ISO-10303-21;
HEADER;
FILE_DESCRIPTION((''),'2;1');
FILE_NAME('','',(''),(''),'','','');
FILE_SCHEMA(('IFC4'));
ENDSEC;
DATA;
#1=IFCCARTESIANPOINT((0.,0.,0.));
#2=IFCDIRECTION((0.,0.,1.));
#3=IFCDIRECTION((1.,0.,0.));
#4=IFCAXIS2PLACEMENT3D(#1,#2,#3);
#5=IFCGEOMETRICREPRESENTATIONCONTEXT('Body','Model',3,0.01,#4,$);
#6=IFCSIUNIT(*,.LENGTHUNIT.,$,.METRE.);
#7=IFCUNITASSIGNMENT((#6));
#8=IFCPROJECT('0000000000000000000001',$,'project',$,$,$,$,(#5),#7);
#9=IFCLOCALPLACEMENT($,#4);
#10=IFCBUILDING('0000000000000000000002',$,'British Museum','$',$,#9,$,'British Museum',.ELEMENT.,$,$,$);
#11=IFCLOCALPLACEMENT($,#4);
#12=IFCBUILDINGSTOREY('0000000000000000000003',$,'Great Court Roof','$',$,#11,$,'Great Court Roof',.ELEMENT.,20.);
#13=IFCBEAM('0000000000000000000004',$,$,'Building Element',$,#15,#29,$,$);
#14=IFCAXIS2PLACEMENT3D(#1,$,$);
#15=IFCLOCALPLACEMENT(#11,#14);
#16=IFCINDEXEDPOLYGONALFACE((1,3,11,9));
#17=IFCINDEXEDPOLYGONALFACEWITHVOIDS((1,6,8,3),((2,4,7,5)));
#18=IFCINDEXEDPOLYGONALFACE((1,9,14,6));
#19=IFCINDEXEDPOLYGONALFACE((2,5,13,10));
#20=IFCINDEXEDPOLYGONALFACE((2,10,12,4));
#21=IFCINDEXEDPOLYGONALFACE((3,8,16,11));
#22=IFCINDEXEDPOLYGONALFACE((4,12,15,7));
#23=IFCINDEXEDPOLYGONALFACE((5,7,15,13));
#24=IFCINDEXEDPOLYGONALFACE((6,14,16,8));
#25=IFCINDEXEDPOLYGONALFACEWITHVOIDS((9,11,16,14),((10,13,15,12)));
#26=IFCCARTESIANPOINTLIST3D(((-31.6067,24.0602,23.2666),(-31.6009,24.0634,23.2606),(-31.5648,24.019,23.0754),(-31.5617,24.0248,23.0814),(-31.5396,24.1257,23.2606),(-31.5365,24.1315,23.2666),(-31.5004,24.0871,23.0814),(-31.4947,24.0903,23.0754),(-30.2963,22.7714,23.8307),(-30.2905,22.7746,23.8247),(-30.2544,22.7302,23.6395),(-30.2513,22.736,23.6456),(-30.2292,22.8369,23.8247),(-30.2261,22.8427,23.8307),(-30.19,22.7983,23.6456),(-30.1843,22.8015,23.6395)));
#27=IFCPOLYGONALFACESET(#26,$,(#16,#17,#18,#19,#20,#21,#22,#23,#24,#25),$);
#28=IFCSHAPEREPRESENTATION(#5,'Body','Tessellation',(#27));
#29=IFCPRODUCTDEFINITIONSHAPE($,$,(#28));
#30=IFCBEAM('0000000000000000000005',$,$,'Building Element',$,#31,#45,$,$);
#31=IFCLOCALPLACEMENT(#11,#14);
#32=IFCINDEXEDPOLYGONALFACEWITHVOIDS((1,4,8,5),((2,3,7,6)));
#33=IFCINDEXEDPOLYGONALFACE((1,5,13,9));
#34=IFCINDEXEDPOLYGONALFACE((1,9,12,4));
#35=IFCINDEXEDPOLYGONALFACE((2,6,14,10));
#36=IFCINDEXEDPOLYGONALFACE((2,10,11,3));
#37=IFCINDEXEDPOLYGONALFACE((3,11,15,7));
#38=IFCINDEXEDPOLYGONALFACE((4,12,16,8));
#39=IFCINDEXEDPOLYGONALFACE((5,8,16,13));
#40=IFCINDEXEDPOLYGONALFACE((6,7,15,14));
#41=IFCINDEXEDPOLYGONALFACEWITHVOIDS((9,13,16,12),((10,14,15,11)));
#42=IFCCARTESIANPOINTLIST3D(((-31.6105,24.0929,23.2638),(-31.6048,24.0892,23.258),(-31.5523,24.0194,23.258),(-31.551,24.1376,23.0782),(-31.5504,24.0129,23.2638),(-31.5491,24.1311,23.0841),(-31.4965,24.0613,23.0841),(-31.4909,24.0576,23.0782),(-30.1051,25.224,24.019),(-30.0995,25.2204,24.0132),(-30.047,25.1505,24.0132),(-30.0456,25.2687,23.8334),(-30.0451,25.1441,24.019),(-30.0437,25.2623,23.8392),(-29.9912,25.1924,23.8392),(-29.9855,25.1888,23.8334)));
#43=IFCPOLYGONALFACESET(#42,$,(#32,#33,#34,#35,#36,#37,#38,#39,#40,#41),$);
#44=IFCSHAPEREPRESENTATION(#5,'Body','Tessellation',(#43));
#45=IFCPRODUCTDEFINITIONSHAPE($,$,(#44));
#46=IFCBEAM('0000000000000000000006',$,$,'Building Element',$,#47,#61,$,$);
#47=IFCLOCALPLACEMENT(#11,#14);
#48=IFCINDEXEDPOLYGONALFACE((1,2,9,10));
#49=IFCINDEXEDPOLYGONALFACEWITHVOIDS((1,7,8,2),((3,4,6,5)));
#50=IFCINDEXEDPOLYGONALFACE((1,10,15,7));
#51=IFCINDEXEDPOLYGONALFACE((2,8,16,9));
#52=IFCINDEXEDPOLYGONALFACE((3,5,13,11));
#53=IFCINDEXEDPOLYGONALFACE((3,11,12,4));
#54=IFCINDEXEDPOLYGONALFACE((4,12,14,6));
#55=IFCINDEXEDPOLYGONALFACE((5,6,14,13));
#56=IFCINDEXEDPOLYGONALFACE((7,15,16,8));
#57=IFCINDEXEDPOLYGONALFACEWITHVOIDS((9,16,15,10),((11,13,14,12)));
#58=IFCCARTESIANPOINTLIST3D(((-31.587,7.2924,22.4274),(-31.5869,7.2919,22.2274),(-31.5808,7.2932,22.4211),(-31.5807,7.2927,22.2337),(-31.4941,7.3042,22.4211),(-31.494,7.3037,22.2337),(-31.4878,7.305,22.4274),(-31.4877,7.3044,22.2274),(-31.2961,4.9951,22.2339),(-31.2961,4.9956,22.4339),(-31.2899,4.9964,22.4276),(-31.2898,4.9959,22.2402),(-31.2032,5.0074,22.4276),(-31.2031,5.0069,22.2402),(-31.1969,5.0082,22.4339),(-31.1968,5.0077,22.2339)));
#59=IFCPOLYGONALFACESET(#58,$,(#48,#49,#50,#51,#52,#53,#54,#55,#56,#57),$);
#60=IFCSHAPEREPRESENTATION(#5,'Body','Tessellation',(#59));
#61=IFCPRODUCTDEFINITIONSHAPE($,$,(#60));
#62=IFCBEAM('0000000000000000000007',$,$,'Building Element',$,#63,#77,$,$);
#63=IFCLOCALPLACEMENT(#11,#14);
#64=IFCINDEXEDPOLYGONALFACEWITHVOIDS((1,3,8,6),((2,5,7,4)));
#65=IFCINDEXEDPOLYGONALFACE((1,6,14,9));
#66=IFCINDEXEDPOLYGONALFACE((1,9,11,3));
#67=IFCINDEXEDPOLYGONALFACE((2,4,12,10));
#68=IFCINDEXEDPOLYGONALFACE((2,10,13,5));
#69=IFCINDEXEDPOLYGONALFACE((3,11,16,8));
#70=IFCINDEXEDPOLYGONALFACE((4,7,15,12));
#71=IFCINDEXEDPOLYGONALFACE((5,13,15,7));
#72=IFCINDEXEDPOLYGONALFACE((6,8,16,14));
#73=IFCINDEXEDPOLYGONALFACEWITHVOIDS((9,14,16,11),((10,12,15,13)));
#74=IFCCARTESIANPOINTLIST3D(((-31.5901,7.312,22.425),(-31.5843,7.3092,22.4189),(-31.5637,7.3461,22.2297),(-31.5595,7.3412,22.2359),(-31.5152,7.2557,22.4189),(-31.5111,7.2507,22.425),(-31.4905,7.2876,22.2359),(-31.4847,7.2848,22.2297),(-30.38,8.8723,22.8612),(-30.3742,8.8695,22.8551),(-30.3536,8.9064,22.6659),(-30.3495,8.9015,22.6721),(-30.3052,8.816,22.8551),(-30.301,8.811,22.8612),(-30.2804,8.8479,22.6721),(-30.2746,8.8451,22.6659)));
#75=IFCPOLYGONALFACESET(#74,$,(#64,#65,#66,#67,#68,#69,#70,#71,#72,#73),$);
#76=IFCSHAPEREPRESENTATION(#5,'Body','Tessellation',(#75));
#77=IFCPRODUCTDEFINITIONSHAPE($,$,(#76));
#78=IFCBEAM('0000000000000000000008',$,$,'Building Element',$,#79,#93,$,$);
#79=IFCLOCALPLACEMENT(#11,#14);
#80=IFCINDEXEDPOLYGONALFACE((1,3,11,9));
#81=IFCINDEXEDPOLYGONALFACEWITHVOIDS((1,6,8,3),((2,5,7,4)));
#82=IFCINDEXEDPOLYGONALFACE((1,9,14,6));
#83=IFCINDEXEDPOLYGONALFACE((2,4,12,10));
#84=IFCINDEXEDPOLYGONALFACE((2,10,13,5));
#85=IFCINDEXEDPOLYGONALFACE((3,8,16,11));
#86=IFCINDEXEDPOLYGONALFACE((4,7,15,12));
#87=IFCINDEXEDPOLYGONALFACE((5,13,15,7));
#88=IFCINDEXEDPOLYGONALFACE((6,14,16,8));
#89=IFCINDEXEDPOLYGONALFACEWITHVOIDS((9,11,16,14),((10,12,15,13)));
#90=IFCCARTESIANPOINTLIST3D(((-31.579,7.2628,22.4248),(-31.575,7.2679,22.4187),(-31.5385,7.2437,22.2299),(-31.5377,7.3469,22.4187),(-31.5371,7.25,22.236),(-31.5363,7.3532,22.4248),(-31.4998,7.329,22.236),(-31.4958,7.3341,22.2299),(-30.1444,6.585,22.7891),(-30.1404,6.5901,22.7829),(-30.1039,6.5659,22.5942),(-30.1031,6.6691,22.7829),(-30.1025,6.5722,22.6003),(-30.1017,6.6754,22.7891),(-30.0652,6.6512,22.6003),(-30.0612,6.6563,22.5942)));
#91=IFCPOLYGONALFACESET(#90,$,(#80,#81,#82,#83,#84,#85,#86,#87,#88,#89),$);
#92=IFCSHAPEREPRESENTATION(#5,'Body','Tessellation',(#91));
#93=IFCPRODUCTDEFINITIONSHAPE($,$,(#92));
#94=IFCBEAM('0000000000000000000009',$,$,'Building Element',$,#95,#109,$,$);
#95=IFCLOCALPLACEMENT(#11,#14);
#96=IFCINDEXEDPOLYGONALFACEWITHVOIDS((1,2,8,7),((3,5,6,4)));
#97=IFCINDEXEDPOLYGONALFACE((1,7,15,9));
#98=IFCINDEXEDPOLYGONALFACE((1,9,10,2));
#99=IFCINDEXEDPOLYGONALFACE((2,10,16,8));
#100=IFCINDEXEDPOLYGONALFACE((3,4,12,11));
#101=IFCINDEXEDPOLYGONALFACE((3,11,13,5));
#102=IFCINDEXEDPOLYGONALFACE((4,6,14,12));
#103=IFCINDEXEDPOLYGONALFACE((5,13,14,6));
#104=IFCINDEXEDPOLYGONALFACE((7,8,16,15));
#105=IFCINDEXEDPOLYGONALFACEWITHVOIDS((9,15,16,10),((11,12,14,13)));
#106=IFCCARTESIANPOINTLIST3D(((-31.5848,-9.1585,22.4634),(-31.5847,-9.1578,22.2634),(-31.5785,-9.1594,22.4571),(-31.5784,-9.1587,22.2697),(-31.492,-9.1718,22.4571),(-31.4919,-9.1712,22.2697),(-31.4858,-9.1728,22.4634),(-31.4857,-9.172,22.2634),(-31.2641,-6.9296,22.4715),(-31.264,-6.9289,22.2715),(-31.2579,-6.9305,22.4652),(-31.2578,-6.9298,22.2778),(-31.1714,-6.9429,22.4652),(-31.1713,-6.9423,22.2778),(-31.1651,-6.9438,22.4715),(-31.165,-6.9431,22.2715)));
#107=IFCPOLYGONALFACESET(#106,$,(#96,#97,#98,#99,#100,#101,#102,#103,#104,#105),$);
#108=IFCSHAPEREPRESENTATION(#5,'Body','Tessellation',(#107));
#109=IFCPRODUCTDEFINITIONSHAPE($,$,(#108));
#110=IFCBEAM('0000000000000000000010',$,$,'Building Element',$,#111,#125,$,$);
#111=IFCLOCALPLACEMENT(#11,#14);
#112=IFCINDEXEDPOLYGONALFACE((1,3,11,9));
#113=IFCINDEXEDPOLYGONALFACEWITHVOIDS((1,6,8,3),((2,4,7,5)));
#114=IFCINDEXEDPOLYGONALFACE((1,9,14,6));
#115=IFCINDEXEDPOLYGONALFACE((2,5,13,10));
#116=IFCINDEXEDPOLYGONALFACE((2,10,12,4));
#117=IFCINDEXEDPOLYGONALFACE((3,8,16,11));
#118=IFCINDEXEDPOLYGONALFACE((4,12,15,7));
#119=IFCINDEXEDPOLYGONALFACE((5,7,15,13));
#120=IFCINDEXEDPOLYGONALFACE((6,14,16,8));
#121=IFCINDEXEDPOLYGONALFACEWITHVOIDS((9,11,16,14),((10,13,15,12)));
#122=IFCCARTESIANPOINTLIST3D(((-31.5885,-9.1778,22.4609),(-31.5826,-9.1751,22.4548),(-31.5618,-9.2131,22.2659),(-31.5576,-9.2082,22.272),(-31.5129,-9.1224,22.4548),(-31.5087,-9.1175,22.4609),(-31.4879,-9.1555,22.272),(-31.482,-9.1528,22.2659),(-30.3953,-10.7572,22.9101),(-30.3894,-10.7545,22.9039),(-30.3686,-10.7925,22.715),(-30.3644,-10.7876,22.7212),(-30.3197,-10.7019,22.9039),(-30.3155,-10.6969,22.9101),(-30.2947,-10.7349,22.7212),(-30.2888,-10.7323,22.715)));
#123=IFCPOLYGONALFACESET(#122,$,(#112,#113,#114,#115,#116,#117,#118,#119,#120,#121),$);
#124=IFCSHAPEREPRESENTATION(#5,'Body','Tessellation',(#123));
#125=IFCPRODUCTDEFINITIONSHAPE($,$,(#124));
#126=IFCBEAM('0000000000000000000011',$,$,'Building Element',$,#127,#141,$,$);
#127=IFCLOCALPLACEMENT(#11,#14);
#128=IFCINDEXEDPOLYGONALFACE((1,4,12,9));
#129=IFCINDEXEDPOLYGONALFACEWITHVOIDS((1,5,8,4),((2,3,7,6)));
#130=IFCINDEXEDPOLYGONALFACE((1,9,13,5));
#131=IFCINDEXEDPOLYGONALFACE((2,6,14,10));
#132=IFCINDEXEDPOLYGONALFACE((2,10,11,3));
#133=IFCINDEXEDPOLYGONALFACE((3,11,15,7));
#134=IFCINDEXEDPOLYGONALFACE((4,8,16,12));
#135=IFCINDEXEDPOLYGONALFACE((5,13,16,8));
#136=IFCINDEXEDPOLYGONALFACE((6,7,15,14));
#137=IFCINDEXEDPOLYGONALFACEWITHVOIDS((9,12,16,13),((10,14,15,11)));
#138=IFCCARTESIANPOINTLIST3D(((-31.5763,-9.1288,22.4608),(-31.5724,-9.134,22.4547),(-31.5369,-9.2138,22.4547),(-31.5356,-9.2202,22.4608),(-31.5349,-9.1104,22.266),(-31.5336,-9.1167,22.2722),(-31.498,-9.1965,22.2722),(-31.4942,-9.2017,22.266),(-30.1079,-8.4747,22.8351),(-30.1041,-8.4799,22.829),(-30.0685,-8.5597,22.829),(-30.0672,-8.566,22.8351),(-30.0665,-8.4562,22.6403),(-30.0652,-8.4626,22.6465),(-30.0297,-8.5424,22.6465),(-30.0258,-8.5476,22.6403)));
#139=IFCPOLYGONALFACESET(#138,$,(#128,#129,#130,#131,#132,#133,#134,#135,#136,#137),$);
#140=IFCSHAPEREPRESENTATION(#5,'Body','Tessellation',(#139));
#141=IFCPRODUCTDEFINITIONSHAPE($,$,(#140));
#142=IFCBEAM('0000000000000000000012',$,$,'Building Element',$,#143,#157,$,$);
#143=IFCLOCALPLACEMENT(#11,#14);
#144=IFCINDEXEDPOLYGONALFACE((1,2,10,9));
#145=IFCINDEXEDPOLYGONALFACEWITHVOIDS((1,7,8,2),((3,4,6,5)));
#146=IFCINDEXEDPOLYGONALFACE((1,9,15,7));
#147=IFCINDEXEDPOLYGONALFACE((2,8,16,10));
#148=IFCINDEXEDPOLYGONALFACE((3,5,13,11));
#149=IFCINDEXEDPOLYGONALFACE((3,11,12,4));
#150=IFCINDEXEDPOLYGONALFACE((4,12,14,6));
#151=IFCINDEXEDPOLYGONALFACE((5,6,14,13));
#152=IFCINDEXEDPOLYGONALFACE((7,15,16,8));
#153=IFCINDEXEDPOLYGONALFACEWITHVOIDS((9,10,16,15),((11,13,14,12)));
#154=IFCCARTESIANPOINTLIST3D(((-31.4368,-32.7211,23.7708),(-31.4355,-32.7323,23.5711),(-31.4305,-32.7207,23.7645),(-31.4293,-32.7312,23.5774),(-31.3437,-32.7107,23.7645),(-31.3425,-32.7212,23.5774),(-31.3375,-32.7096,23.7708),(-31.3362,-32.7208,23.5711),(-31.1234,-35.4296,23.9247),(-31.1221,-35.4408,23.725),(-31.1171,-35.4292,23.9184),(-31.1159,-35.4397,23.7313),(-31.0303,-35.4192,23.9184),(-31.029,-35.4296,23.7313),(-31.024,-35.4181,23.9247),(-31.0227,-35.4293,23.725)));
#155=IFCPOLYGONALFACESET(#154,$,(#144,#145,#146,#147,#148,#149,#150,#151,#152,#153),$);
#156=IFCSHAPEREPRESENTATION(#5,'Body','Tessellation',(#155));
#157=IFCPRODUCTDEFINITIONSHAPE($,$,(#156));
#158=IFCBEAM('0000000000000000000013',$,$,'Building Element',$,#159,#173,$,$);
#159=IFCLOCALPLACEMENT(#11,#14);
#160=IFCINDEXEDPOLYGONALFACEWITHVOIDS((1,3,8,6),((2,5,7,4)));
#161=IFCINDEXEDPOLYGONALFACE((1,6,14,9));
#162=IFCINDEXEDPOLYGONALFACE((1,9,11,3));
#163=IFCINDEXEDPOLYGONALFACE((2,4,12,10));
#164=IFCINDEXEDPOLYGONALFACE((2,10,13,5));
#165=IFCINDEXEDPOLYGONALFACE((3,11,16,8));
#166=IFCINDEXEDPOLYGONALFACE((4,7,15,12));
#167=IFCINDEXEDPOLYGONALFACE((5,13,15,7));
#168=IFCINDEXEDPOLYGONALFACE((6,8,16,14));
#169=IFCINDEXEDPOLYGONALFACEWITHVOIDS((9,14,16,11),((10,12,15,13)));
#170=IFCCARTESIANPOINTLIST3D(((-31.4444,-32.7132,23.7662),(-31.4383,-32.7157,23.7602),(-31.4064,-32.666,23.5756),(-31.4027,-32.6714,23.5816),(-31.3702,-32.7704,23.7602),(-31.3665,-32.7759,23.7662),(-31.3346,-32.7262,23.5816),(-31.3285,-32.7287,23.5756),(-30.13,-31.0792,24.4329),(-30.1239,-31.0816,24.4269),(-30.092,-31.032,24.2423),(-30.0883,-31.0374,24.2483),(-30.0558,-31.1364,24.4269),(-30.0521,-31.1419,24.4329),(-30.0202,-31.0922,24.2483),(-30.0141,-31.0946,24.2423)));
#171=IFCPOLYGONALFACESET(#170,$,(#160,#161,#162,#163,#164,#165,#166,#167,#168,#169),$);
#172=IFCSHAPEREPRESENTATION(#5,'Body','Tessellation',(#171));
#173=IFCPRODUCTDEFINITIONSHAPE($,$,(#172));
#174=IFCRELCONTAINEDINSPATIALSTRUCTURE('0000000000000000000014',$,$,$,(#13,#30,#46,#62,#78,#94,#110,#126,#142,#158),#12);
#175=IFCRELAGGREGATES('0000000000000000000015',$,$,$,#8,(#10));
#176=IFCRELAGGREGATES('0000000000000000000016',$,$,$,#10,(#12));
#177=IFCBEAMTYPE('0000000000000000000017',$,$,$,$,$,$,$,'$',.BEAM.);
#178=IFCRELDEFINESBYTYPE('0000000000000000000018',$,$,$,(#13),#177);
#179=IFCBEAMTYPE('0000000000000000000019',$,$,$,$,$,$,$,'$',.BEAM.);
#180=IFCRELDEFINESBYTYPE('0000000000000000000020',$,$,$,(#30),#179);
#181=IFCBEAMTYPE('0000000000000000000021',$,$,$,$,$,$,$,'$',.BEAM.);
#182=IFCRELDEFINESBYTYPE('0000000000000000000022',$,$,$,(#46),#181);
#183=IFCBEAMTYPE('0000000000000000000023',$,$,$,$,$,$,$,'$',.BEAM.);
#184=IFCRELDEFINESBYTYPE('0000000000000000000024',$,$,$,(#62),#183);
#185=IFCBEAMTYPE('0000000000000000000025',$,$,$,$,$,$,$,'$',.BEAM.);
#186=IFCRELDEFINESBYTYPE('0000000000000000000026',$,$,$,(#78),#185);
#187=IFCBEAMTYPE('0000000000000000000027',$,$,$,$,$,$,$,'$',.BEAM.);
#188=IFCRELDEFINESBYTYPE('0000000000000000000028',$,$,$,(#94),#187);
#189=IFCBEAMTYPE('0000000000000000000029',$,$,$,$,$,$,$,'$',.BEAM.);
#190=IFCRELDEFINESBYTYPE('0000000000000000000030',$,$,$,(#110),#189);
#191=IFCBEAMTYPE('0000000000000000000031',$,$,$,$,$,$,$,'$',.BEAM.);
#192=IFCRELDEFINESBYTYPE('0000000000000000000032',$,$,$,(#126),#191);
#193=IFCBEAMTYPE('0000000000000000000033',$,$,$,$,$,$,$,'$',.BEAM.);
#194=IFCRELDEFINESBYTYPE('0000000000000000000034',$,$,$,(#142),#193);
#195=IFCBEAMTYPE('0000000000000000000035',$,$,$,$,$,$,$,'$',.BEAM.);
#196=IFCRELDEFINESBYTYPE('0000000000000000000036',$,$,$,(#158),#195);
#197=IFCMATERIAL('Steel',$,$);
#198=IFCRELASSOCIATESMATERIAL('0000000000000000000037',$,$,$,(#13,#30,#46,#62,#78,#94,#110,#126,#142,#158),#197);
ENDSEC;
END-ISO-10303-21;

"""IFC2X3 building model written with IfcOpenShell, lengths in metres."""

from ifc_helpers import new_model, si_unit, frame, origin_with_axes, origin_2d, place, context, project, spatial, hollow_rectangle, extrude, material, type_object, element, save


model = new_model("IFC2X3")

# Units and contexts
model_context = context("Model", 3, precision=0.01, world=origin_with_axes(), identifier="Body")
ifc_project = project(units=[si_unit("LENGTHUNIT", "METRE")], contexts=[model_context])

# Building, storey
building_placement = place(None, origin_with_axes())
building = spatial("IfcBuilding", under=ifc_project, at=building_placement, Name="British Museum", Description="$", LongName="British Museum", CompositionType="ELEMENT")
storey_placement = place(None, origin_with_axes())
storey = spatial("IfcBuildingStorey", under=building, at=storey_placement, Name="Great Court Roof", Description="$", LongName="Great Court Roof", CompositionType="ELEMENT", Elevation=20.0)

# Beams
ifc_material = material(Name="Steel")
beam_type_1 = type_object("IfcBeamType", ElementType="$", PredefinedType="BEAM")
beam_1_placement = place(None, origin_with_axes())
element("IfcBeam", 1, at=beam_1_placement, inside=storey, type_object=beam_type_1, material=ifc_material, Description="Building Element", context=model_context, shape_type="SweptSolid", body=[
    extrude(hollow_rectangle(XDim=0.1, YDim=0.2, WallThickness=0.0063, InnerFilletRadius=-0.0063, OuterFilletRadius=0.0, at=origin_2d()), frame((-31.5507, 24.0753, 23.171), z_axis=(0.681582, -0.67034, 0.293411), x_axis=(0.701202, 0.712962, 0.0)), (0.0, 0.0, 1.0), 1.9226),
])
beam_type_2 = type_object("IfcBeamType", ElementType="$", PredefinedType="BEAM")
beam_2_placement = place(None, origin_with_axes())
element("IfcBeam", 2, at=beam_2_placement, inside=storey, type_object=beam_type_2, material=ifc_material, Description="Building Element", context=model_context, shape_type="SweptSolid", body=[
    extrude(hollow_rectangle(XDim=0.1, YDim=0.2, WallThickness=0.0063, InnerFilletRadius=-0.0063, OuterFilletRadius=0.0, at=origin_2d()), frame((-31.5507, 24.0753, 23.171), z_axis=(0.742004, 0.557559, 0.372235), x_axis=(-0.600728, 0.799453, 0.0)), (0.0, 0.0, 1.0), 2.0288),
])
beam_type_3 = type_object("IfcBeamType", ElementType="$", PredefinedType="BEAM")
beam_3_placement = place(None, origin_with_axes())
element("IfcBeam", 3, at=beam_3_placement, inside=storey, type_object=beam_type_3, material=ifc_material, Description="Building Element", context=model_context, shape_type="SweptSolid", body=[
    extrude(hollow_rectangle(XDim=0.1, YDim=0.2, WallThickness=0.0063, InnerFilletRadius=-0.0063, OuterFilletRadius=0.0, at=origin_2d()), frame((-31.5374, 7.2984, 22.3274), z_axis=(0.125649, -0.992071, 0.002808), x_axis=(0.992075, 0.12565, 0.0)), (0.0, 0.0, 1.0), 2.3151),
])
beam_type_4 = type_object("IfcBeamType", ElementType="$", PredefinedType="BEAM")
beam_4_placement = place(None, origin_with_axes())
element("IfcBeam", 4, at=beam_4_placement, inside=storey, type_object=beam_type_4, material=ifc_material, Description="Building Element", context=model_context, shape_type="SweptSolid", body=[
    extrude(hollow_rectangle(XDim=0.1, YDim=0.2, WallThickness=0.0063, InnerFilletRadius=-0.0063, OuterFilletRadius=0.0, at=origin_2d()), frame((-31.5374, 7.2984, 22.3274), z_axis=(0.59841, 0.771605, 0.21571), x_axis=(-0.790209, 0.612838, 0.0)), (0.0, 0.0, 1.0), 2.0221),
])
beam_type_5 = type_object("IfcBeamType", ElementType="$", PredefinedType="BEAM")
beam_5_placement = place(None, origin_with_axes())
element("IfcBeam", 5, at=beam_5_placement, inside=storey, type_object=beam_type_5, material=ifc_material, Description="Building Element", context=model_context, shape_type="SweptSolid", body=[
    extrude(hollow_rectangle(XDim=0.1, YDim=0.2, WallThickness=0.0063, InnerFilletRadius=-0.0063, OuterFilletRadius=0.0, at=origin_2d()), frame((-31.5374, 7.2984, 22.3274), z_axis=(0.881238, -0.416356, 0.223755), x_axis=(0.427187, 0.904163, 0.0)), (0.0, 0.0, 1.0), 1.6279),
])
beam_type_6 = type_object("IfcBeamType", ElementType="$", PredefinedType="BEAM")
beam_6_placement = place(None, origin_with_axes())
element("IfcBeam", 6, at=beam_6_placement, inside=storey, type_object=beam_type_6, material=ifc_material, Description="Building Element", context=model_context, shape_type="SweptSolid", body=[
    extrude(hollow_rectangle(XDim=0.1, YDim=0.2, WallThickness=0.0063, InnerFilletRadius=-0.0063, OuterFilletRadius=0.0, at=origin_2d()), frame((-31.5352, -9.1653, 22.3634), z_axis=(0.142392, 0.989804, 0.003598), x_axis=(-0.98981, 0.142393, 0.0)), (0.0, 0.0, 1.0), 2.2519),
])
beam_type_7 = type_object("IfcBeamType", ElementType="$", PredefinedType="BEAM")
beam_7_placement = place(None, origin_with_axes())
element("IfcBeam", 7, at=beam_7_placement, inside=storey, type_object=beam_type_7, material=ifc_material, Description="Building Element", context=model_context, shape_type="SweptSolid", body=[
    extrude(hollow_rectangle(XDim=0.1, YDim=0.2, WallThickness=0.0063, InnerFilletRadius=-0.0063, OuterFilletRadius=0.0, at=origin_2d()), frame((-31.5352, -9.1653, 22.3634), z_axis=(0.587828, -0.778139, 0.221265), x_axis=(0.797916, 0.602768, 0.0)), (0.0, 0.0, 1.0), 2.0298),
])
beam_type_8 = type_object("IfcBeamType", ElementType="$", PredefinedType="BEAM")
beam_8_placement = place(None, origin_with_axes())
element("IfcBeam", 8, at=beam_8_placement, inside=storey, type_object=beam_type_8, material=ifc_material, Description="Building Element", context=model_context, shape_type="SweptSolid", body=[
    extrude(hollow_rectangle(XDim=0.1, YDim=0.2, WallThickness=0.0063, InnerFilletRadius=-0.0063, OuterFilletRadius=0.0, at=origin_2d()), frame((-31.5352, -9.1653, 22.3634), z_axis=(0.889658, 0.396327, 0.226789), x_axis=(-0.40693, 0.913459, 0.0)), (0.0, 0.0, 1.0), 1.6505),
])
beam_type_9 = type_object("IfcBeamType", ElementType="$", PredefinedType="BEAM")
beam_9_placement = place(None, origin_with_axes())
element("IfcBeam", 9, at=beam_9_placement, inside=storey, type_object=beam_type_9, material=ifc_material, Description="Building Element", context=model_context, shape_type="SweptSolid", body=[
    extrude(hollow_rectangle(XDim=0.1, YDim=0.2, WallThickness=0.0063, InnerFilletRadius=-0.0063, OuterFilletRadius=0.0, at=origin_2d()), frame((-31.3865, -32.7209, 23.6709), z_axis=(0.114766, -0.991792, 0.056367), x_axis=(0.993371, 0.114948, 0.0)), (0.0, 0.0, 1.0), 2.7309),
])
beam_type_10 = type_object("IfcBeamType", ElementType="$", PredefinedType="BEAM")
beam_10_placement = place(None, origin_with_axes())
element("IfcBeam", 10, at=beam_10_placement, inside=storey, type_object=beam_type_10, material=ifc_material, Description="Building Element", context=model_context, shape_type="SweptSolid", body=[
    extrude(hollow_rectangle(XDim=0.1, YDim=0.2, WallThickness=0.0063, InnerFilletRadius=-0.0063, OuterFilletRadius=0.0, at=origin_2d()), frame((-31.3865, -32.7209, 23.6709), z_axis=(0.597335, 0.742565, 0.302966), x_axis=(-0.779186, 0.626793, 0.0)), (0.0, 0.0, 1.0), 2.2005),
])

save(model, "model.ifc")
